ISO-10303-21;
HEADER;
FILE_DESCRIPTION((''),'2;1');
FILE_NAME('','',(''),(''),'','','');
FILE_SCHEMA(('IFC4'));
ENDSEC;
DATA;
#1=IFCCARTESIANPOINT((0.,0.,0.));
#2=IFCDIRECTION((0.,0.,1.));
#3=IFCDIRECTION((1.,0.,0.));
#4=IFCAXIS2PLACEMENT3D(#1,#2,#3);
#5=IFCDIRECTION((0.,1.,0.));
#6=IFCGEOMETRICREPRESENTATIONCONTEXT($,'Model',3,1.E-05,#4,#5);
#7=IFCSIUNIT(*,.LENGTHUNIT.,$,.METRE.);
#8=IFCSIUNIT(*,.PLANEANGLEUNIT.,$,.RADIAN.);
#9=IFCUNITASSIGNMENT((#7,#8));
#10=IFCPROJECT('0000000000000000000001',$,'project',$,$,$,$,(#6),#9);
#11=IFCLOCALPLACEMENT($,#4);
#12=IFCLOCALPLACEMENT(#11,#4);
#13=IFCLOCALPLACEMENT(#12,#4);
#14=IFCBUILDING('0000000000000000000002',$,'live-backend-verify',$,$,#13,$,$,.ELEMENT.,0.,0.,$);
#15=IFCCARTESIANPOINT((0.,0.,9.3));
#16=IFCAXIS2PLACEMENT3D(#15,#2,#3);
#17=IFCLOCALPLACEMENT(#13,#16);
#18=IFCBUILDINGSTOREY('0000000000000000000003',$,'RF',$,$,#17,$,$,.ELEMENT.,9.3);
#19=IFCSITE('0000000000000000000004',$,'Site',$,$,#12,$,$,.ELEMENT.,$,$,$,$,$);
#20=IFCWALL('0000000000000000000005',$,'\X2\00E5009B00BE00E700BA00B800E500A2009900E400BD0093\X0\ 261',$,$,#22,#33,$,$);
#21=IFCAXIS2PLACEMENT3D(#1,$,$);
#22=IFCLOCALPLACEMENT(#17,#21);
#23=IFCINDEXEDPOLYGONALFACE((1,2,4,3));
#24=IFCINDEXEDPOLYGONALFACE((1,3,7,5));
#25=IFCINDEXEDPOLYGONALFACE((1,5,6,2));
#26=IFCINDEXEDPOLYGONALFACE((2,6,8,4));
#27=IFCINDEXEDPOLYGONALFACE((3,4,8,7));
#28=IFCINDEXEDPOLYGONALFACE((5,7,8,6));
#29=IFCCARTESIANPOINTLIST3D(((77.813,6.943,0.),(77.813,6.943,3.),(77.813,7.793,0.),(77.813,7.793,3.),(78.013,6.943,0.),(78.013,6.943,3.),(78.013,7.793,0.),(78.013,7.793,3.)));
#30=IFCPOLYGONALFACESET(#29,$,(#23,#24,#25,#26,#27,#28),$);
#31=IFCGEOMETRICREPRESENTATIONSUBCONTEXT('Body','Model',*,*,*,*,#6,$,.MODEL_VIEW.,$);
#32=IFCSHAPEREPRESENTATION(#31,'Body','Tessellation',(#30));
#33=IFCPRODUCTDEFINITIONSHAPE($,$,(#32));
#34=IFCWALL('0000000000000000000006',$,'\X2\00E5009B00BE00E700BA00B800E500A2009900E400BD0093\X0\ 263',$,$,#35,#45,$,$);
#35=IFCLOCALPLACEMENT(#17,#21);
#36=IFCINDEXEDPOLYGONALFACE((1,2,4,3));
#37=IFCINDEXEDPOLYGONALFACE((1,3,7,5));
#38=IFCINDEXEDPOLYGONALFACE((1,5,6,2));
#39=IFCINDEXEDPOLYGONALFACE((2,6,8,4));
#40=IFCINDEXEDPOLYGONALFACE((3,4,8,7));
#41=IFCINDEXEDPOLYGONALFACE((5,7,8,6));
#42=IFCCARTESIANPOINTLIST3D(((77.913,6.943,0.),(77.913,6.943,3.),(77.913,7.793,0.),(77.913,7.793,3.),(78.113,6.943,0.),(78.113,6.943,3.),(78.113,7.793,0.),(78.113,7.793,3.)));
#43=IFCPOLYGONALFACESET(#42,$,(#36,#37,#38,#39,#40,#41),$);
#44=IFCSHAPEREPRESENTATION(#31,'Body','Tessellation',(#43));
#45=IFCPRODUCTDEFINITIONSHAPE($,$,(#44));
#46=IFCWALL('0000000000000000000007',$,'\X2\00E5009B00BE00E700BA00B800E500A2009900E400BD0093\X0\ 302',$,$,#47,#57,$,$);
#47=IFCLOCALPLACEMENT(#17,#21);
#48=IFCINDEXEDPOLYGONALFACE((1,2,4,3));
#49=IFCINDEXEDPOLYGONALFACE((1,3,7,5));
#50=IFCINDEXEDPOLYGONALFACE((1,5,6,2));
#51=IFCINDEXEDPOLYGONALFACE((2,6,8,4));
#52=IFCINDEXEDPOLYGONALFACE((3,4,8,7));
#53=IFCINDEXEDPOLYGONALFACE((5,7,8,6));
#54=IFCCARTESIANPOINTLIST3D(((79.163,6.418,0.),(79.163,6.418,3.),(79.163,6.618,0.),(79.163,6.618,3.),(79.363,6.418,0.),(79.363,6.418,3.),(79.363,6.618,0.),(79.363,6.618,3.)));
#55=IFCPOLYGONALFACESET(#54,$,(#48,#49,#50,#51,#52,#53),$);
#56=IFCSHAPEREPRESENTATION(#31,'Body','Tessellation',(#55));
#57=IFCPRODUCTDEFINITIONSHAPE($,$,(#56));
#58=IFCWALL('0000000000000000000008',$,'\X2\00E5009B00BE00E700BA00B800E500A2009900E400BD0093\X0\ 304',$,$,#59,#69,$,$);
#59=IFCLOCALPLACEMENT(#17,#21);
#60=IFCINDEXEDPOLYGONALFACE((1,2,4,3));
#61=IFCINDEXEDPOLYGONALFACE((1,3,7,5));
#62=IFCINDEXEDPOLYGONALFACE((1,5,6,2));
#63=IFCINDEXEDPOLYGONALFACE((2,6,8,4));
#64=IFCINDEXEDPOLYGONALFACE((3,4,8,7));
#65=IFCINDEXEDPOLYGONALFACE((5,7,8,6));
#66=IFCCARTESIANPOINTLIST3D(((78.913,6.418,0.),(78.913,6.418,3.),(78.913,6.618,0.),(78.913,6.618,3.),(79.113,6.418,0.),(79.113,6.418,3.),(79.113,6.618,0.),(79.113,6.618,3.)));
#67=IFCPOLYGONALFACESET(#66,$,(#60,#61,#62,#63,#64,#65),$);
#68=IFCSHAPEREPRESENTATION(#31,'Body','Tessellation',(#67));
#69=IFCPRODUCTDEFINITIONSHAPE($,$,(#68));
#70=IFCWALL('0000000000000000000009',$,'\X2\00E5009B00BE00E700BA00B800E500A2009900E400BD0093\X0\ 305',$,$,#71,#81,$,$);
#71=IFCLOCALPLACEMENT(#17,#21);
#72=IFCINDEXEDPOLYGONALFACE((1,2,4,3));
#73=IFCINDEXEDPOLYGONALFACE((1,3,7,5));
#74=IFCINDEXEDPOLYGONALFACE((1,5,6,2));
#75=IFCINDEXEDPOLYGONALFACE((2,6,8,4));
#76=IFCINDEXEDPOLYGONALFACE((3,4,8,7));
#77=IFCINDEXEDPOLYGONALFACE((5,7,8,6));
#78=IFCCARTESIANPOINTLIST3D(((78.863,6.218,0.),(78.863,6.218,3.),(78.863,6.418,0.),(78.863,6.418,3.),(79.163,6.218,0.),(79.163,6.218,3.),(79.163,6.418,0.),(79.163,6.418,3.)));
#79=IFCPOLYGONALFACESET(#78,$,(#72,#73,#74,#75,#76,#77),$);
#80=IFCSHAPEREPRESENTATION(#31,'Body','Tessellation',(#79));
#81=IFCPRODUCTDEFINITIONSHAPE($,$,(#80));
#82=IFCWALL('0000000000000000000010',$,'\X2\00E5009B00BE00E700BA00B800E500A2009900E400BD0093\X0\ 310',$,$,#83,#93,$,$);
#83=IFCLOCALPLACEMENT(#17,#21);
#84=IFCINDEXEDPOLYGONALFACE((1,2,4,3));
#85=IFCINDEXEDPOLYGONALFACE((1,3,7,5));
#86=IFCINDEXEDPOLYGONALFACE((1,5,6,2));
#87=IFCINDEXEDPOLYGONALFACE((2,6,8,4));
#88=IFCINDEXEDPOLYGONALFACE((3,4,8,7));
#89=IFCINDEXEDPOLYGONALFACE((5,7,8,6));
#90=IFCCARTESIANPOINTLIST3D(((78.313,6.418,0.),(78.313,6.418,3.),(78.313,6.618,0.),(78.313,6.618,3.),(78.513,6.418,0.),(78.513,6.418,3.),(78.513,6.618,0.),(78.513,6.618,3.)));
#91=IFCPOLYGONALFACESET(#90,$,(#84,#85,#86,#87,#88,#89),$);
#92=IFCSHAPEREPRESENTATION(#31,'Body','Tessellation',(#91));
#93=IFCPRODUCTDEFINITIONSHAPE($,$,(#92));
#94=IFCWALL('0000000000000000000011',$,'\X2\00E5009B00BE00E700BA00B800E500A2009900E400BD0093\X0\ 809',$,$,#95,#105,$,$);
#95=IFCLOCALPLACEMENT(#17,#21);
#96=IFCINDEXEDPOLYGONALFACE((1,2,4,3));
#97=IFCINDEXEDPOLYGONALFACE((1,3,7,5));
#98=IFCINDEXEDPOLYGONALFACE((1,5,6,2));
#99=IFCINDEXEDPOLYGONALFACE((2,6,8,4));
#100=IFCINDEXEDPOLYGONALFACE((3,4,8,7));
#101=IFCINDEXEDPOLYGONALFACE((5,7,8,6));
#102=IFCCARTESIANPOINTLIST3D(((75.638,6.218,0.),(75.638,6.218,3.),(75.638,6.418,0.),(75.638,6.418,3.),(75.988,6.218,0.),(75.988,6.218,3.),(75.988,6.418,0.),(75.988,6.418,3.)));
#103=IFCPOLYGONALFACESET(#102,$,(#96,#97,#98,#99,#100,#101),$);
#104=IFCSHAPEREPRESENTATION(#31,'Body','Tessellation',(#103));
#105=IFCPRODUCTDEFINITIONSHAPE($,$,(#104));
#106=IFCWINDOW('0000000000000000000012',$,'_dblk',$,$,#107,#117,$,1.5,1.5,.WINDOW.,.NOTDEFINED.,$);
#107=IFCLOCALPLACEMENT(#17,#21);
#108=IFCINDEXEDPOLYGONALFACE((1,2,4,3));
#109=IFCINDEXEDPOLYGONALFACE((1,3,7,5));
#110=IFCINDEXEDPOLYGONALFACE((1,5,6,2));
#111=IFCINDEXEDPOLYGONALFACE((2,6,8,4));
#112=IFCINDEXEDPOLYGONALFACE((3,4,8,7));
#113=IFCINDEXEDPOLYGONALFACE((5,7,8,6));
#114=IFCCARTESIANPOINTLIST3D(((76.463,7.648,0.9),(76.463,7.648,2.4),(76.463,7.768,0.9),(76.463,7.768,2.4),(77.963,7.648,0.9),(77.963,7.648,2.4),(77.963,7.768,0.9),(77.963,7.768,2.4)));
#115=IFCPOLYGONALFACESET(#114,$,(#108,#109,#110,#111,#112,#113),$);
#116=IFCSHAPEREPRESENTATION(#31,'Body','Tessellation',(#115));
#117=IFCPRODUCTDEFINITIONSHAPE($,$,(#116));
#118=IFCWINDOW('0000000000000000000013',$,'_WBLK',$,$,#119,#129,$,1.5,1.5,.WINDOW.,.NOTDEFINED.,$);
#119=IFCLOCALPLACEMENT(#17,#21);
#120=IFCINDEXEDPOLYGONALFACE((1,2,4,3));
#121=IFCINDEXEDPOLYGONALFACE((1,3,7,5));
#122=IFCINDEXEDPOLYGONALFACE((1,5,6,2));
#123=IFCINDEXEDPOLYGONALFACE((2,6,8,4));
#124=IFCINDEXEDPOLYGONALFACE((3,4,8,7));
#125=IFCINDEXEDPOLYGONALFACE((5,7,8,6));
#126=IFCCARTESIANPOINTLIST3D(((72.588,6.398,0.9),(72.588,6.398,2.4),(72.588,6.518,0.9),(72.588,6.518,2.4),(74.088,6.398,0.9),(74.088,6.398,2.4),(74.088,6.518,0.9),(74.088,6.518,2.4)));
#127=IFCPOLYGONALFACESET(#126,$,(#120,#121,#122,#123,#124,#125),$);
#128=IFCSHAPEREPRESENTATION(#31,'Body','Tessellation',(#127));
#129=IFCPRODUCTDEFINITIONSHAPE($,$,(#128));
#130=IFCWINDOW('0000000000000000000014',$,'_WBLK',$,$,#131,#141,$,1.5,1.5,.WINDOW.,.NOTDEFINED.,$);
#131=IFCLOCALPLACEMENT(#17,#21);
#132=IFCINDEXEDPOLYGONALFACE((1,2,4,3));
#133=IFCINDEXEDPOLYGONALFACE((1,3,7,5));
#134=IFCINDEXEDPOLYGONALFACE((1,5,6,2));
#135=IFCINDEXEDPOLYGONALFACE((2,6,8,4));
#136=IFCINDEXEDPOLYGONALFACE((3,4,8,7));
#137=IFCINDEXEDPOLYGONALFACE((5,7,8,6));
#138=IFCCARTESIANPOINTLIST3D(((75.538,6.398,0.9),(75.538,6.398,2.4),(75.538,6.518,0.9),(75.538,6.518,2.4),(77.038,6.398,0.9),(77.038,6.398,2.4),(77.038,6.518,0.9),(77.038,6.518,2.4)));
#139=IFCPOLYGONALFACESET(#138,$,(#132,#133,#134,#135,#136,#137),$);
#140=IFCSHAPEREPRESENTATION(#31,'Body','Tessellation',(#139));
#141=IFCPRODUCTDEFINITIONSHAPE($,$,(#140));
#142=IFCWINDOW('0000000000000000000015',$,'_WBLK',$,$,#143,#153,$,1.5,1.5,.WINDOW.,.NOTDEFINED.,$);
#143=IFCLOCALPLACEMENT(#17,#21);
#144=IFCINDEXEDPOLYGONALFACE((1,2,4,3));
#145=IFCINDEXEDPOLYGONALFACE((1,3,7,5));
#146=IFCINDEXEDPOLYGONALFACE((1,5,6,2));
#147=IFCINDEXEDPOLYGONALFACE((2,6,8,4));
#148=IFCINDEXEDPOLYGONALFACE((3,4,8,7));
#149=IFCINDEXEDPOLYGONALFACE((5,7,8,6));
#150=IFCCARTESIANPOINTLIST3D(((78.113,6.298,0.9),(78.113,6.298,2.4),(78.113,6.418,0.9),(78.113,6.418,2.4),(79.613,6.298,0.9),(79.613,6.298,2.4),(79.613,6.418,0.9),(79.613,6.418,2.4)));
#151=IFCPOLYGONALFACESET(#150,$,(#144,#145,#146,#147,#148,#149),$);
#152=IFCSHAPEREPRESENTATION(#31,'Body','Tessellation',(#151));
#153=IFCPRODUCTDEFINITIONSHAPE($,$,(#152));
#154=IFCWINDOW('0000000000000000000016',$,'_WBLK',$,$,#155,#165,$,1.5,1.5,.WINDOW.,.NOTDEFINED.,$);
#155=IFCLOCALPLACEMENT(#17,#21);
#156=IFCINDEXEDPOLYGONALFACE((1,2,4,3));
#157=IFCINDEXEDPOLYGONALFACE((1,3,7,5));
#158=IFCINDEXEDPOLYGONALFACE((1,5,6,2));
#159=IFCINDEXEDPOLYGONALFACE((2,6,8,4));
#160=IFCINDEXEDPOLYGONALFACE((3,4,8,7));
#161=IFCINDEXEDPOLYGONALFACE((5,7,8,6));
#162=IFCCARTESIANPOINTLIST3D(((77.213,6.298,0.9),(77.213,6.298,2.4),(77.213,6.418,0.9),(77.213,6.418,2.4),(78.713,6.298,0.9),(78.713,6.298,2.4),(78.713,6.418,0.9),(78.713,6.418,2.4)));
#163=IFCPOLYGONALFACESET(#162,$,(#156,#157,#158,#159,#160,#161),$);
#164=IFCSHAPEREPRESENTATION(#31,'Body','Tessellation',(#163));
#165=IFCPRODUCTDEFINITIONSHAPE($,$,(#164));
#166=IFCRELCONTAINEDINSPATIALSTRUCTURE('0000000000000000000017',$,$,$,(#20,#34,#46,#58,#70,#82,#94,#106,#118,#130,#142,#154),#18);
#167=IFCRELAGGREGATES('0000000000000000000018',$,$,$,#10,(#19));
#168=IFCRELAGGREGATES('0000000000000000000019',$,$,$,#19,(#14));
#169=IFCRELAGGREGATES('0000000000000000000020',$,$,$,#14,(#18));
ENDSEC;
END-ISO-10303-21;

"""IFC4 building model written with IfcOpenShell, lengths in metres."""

from ifc_helpers import new_model, si_unit, direction, frame, frame_2d, origin_with_axes, place, context, subcontext, project, spatial, rectangle, extrude, element, save


model = new_model("IFC4")

# Units and contexts
model_context = context("Model", 3, precision=1e-05, world=origin_with_axes(), true_north=direction((0.0, 1.0, 0.0)))
body_context = subcontext(model_context, "Body", "Model", "MODEL_VIEW")
ifc_project = project(units=[si_unit("LENGTHUNIT", "METRE"), si_unit("PLANEANGLEUNIT", "RADIAN")], contexts=[model_context])

# Site, building, storey
placement = place(None, origin_with_axes())
site_placement = place(placement, origin_with_axes())
site = spatial("IfcSite", under=ifc_project, at=site_placement, Name="Site", CompositionType="ELEMENT")
building_placement = place(site_placement, origin_with_axes())
building = spatial("IfcBuilding", under=site, at=building_placement, Name="live-backend-verify", CompositionType="ELEMENT", ElevationOfRefHeight=0.0, ElevationOfTerrain=0.0)
storey_placement = place(building_placement, frame((0.0, 0.0, 9.3), z_axis=(0.0, 0.0, 1.0), x_axis=(1.0, 0.0, 0.0)))
storey = spatial("IfcBuildingStorey", under=building, at=storey_placement, Name="RF", CompositionType="ELEMENT", Elevation=9.3)

# Walls
for number, where, z_axis, x_axis, name in (
    (1, (77.913, 7.368, 0.0), (0.0, 0.0, 1.0), (0.0, -1.0, 0.0), "å\u009b¾çº¸å¢\u0099ä½\u0093 261"),
    (2, (78.013, 7.368, 0.0), (0.0, 0.0, 1.0), (0.0, -1.0, 0.0), "å\u009b¾çº¸å¢\u0099ä½\u0093 263"),
):
    element("IfcWall", number, at=place(storey_placement, frame(where, z_axis=z_axis, x_axis=x_axis)), inside=storey, Name=name, context=body_context, shape_type="SweptSolid", body=[
        extrude(rectangle(XDim=0.85, YDim=0.2, at=frame_2d((0.0, 0.0), x_axis=(1.0, 0.0, 0.0))), frame((0.0, 0.0, 0.0), z_axis=(0.0, 0.0, 1.0)), (0.0, 0.0, 1.0), 3.0),
    ])
for number, where, z_axis, x_axis, name in (
    (3, (79.263, 6.518, 0.0), (0.0, 0.0, 1.0), (1.0, 0.0, 0.0), "å\u009b¾çº¸å¢\u0099ä½\u0093 302"),
    (4, (79.013, 6.518, 0.0), (0.0, 0.0, 1.0), (1.0, 0.0, 0.0), "å\u009b¾çº¸å¢\u0099ä½\u0093 304"),
):
    element("IfcWall", number, at=place(storey_placement, frame(where, z_axis=z_axis, x_axis=x_axis)), inside=storey, Name=name, context=body_context, shape_type="SweptSolid", body=[
        extrude(rectangle(XDim=0.2, YDim=0.2, at=frame_2d((0.0, 0.0), x_axis=(1.0, 0.0, 0.0))), frame((0.0, 0.0, 0.0), z_axis=(0.0, 0.0, 1.0)), (0.0, 0.0, 1.0), 3.0),
    ])
wall_1_placement = place(storey_placement, frame((79.013, 6.318, 0.0), z_axis=(0.0, 0.0, 1.0), x_axis=(1.0, 0.0, 0.0)))
element("IfcWall", 5, at=wall_1_placement, inside=storey, Name="å\u009b¾çº¸å¢\u0099ä½\u0093 305", context=body_context, shape_type="SweptSolid", body=[
    extrude(rectangle(XDim=0.3, YDim=0.2, at=frame_2d((0.0, 0.0), x_axis=(1.0, 0.0, 0.0))), frame((0.0, 0.0, 0.0), z_axis=(0.0, 0.0, 1.0)), (0.0, 0.0, 1.0), 3.0),
])
for number, where, z_axis, x_axis, name in (
    (6, (78.413, 6.518, 0.0), (0.0, 0.0, 1.0), (0.0, -1.0, 0.0), "å\u009b¾çº¸å¢\u0099ä½\u0093 310"),
):
    element("IfcWall", number, at=place(storey_placement, frame(where, z_axis=z_axis, x_axis=x_axis)), inside=storey, Name=name, context=body_context, shape_type="SweptSolid", body=[
        extrude(rectangle(XDim=0.2, YDim=0.2, at=frame_2d((0.0, 0.0), x_axis=(1.0, 0.0, 0.0))), frame((0.0, 0.0, 0.0), z_axis=(0.0, 0.0, 1.0)), (0.0, 0.0, 1.0), 3.0),
    ])
wall_2_placement = place(storey_placement, frame((75.813, 6.318, 0.0), z_axis=(0.0, 0.0, 1.0), x_axis=(1.0, 0.0, 0.0)))
element("IfcWall", 7, at=wall_2_placement, inside=storey, Name="å\u009b¾çº¸å¢\u0099ä½\u0093 809", context=body_context, shape_type="SweptSolid", body=[
    extrude(rectangle(XDim=0.35, YDim=0.2, at=frame_2d((0.0, 0.0), x_axis=(1.0, 0.0, 0.0))), frame((0.0, 0.0, 0.0), z_axis=(0.0, 0.0, 1.0)), (0.0, 0.0, 1.0), 3.0),
])

# Windows
for number, where, z_axis, x_axis, name in (
    (8, (77.213, 7.708, 0.9), (0.0, 0.0, 1.0), (1.0, 0.0, 0.0), "_dblk"),
    (9, (73.338, 6.458, 0.9), (0.0, 0.0, 1.0), (1.0, 0.0, 0.0), "_WBLK"),
    (10, (76.288, 6.458, 0.9), (0.0, 0.0, 1.0), (1.0, 0.0, 0.0), "_WBLK"),
    (11, (78.863, 6.358, 0.9), (0.0, 0.0, 1.0), (1.0, 0.0, 0.0), "_WBLK"),
    (12, (77.963, 6.358, 0.9), (0.0, 0.0, 1.0), (1.0, 0.0, 0.0), "_WBLK"),
):
    element("IfcWindow", number, at=place(storey_placement, frame(where, z_axis=z_axis, x_axis=x_axis)), inside=storey, Name=name, OverallHeight=1.5, OverallWidth=1.5, PartitioningType="NOTDEFINED", PredefinedType="WINDOW", context=body_context, shape_type="SweptSolid", body=[
        extrude(rectangle(XDim=1.5, YDim=0.12, at=frame_2d((0.0, 0.0), x_axis=(1.0, 0.0, 0.0))), frame((0.0, 0.0, 0.0), z_axis=(0.0, 0.0, 1.0)), (0.0, 0.0, 1.0), 1.5),
    ])

save(model, "model.ifc")
